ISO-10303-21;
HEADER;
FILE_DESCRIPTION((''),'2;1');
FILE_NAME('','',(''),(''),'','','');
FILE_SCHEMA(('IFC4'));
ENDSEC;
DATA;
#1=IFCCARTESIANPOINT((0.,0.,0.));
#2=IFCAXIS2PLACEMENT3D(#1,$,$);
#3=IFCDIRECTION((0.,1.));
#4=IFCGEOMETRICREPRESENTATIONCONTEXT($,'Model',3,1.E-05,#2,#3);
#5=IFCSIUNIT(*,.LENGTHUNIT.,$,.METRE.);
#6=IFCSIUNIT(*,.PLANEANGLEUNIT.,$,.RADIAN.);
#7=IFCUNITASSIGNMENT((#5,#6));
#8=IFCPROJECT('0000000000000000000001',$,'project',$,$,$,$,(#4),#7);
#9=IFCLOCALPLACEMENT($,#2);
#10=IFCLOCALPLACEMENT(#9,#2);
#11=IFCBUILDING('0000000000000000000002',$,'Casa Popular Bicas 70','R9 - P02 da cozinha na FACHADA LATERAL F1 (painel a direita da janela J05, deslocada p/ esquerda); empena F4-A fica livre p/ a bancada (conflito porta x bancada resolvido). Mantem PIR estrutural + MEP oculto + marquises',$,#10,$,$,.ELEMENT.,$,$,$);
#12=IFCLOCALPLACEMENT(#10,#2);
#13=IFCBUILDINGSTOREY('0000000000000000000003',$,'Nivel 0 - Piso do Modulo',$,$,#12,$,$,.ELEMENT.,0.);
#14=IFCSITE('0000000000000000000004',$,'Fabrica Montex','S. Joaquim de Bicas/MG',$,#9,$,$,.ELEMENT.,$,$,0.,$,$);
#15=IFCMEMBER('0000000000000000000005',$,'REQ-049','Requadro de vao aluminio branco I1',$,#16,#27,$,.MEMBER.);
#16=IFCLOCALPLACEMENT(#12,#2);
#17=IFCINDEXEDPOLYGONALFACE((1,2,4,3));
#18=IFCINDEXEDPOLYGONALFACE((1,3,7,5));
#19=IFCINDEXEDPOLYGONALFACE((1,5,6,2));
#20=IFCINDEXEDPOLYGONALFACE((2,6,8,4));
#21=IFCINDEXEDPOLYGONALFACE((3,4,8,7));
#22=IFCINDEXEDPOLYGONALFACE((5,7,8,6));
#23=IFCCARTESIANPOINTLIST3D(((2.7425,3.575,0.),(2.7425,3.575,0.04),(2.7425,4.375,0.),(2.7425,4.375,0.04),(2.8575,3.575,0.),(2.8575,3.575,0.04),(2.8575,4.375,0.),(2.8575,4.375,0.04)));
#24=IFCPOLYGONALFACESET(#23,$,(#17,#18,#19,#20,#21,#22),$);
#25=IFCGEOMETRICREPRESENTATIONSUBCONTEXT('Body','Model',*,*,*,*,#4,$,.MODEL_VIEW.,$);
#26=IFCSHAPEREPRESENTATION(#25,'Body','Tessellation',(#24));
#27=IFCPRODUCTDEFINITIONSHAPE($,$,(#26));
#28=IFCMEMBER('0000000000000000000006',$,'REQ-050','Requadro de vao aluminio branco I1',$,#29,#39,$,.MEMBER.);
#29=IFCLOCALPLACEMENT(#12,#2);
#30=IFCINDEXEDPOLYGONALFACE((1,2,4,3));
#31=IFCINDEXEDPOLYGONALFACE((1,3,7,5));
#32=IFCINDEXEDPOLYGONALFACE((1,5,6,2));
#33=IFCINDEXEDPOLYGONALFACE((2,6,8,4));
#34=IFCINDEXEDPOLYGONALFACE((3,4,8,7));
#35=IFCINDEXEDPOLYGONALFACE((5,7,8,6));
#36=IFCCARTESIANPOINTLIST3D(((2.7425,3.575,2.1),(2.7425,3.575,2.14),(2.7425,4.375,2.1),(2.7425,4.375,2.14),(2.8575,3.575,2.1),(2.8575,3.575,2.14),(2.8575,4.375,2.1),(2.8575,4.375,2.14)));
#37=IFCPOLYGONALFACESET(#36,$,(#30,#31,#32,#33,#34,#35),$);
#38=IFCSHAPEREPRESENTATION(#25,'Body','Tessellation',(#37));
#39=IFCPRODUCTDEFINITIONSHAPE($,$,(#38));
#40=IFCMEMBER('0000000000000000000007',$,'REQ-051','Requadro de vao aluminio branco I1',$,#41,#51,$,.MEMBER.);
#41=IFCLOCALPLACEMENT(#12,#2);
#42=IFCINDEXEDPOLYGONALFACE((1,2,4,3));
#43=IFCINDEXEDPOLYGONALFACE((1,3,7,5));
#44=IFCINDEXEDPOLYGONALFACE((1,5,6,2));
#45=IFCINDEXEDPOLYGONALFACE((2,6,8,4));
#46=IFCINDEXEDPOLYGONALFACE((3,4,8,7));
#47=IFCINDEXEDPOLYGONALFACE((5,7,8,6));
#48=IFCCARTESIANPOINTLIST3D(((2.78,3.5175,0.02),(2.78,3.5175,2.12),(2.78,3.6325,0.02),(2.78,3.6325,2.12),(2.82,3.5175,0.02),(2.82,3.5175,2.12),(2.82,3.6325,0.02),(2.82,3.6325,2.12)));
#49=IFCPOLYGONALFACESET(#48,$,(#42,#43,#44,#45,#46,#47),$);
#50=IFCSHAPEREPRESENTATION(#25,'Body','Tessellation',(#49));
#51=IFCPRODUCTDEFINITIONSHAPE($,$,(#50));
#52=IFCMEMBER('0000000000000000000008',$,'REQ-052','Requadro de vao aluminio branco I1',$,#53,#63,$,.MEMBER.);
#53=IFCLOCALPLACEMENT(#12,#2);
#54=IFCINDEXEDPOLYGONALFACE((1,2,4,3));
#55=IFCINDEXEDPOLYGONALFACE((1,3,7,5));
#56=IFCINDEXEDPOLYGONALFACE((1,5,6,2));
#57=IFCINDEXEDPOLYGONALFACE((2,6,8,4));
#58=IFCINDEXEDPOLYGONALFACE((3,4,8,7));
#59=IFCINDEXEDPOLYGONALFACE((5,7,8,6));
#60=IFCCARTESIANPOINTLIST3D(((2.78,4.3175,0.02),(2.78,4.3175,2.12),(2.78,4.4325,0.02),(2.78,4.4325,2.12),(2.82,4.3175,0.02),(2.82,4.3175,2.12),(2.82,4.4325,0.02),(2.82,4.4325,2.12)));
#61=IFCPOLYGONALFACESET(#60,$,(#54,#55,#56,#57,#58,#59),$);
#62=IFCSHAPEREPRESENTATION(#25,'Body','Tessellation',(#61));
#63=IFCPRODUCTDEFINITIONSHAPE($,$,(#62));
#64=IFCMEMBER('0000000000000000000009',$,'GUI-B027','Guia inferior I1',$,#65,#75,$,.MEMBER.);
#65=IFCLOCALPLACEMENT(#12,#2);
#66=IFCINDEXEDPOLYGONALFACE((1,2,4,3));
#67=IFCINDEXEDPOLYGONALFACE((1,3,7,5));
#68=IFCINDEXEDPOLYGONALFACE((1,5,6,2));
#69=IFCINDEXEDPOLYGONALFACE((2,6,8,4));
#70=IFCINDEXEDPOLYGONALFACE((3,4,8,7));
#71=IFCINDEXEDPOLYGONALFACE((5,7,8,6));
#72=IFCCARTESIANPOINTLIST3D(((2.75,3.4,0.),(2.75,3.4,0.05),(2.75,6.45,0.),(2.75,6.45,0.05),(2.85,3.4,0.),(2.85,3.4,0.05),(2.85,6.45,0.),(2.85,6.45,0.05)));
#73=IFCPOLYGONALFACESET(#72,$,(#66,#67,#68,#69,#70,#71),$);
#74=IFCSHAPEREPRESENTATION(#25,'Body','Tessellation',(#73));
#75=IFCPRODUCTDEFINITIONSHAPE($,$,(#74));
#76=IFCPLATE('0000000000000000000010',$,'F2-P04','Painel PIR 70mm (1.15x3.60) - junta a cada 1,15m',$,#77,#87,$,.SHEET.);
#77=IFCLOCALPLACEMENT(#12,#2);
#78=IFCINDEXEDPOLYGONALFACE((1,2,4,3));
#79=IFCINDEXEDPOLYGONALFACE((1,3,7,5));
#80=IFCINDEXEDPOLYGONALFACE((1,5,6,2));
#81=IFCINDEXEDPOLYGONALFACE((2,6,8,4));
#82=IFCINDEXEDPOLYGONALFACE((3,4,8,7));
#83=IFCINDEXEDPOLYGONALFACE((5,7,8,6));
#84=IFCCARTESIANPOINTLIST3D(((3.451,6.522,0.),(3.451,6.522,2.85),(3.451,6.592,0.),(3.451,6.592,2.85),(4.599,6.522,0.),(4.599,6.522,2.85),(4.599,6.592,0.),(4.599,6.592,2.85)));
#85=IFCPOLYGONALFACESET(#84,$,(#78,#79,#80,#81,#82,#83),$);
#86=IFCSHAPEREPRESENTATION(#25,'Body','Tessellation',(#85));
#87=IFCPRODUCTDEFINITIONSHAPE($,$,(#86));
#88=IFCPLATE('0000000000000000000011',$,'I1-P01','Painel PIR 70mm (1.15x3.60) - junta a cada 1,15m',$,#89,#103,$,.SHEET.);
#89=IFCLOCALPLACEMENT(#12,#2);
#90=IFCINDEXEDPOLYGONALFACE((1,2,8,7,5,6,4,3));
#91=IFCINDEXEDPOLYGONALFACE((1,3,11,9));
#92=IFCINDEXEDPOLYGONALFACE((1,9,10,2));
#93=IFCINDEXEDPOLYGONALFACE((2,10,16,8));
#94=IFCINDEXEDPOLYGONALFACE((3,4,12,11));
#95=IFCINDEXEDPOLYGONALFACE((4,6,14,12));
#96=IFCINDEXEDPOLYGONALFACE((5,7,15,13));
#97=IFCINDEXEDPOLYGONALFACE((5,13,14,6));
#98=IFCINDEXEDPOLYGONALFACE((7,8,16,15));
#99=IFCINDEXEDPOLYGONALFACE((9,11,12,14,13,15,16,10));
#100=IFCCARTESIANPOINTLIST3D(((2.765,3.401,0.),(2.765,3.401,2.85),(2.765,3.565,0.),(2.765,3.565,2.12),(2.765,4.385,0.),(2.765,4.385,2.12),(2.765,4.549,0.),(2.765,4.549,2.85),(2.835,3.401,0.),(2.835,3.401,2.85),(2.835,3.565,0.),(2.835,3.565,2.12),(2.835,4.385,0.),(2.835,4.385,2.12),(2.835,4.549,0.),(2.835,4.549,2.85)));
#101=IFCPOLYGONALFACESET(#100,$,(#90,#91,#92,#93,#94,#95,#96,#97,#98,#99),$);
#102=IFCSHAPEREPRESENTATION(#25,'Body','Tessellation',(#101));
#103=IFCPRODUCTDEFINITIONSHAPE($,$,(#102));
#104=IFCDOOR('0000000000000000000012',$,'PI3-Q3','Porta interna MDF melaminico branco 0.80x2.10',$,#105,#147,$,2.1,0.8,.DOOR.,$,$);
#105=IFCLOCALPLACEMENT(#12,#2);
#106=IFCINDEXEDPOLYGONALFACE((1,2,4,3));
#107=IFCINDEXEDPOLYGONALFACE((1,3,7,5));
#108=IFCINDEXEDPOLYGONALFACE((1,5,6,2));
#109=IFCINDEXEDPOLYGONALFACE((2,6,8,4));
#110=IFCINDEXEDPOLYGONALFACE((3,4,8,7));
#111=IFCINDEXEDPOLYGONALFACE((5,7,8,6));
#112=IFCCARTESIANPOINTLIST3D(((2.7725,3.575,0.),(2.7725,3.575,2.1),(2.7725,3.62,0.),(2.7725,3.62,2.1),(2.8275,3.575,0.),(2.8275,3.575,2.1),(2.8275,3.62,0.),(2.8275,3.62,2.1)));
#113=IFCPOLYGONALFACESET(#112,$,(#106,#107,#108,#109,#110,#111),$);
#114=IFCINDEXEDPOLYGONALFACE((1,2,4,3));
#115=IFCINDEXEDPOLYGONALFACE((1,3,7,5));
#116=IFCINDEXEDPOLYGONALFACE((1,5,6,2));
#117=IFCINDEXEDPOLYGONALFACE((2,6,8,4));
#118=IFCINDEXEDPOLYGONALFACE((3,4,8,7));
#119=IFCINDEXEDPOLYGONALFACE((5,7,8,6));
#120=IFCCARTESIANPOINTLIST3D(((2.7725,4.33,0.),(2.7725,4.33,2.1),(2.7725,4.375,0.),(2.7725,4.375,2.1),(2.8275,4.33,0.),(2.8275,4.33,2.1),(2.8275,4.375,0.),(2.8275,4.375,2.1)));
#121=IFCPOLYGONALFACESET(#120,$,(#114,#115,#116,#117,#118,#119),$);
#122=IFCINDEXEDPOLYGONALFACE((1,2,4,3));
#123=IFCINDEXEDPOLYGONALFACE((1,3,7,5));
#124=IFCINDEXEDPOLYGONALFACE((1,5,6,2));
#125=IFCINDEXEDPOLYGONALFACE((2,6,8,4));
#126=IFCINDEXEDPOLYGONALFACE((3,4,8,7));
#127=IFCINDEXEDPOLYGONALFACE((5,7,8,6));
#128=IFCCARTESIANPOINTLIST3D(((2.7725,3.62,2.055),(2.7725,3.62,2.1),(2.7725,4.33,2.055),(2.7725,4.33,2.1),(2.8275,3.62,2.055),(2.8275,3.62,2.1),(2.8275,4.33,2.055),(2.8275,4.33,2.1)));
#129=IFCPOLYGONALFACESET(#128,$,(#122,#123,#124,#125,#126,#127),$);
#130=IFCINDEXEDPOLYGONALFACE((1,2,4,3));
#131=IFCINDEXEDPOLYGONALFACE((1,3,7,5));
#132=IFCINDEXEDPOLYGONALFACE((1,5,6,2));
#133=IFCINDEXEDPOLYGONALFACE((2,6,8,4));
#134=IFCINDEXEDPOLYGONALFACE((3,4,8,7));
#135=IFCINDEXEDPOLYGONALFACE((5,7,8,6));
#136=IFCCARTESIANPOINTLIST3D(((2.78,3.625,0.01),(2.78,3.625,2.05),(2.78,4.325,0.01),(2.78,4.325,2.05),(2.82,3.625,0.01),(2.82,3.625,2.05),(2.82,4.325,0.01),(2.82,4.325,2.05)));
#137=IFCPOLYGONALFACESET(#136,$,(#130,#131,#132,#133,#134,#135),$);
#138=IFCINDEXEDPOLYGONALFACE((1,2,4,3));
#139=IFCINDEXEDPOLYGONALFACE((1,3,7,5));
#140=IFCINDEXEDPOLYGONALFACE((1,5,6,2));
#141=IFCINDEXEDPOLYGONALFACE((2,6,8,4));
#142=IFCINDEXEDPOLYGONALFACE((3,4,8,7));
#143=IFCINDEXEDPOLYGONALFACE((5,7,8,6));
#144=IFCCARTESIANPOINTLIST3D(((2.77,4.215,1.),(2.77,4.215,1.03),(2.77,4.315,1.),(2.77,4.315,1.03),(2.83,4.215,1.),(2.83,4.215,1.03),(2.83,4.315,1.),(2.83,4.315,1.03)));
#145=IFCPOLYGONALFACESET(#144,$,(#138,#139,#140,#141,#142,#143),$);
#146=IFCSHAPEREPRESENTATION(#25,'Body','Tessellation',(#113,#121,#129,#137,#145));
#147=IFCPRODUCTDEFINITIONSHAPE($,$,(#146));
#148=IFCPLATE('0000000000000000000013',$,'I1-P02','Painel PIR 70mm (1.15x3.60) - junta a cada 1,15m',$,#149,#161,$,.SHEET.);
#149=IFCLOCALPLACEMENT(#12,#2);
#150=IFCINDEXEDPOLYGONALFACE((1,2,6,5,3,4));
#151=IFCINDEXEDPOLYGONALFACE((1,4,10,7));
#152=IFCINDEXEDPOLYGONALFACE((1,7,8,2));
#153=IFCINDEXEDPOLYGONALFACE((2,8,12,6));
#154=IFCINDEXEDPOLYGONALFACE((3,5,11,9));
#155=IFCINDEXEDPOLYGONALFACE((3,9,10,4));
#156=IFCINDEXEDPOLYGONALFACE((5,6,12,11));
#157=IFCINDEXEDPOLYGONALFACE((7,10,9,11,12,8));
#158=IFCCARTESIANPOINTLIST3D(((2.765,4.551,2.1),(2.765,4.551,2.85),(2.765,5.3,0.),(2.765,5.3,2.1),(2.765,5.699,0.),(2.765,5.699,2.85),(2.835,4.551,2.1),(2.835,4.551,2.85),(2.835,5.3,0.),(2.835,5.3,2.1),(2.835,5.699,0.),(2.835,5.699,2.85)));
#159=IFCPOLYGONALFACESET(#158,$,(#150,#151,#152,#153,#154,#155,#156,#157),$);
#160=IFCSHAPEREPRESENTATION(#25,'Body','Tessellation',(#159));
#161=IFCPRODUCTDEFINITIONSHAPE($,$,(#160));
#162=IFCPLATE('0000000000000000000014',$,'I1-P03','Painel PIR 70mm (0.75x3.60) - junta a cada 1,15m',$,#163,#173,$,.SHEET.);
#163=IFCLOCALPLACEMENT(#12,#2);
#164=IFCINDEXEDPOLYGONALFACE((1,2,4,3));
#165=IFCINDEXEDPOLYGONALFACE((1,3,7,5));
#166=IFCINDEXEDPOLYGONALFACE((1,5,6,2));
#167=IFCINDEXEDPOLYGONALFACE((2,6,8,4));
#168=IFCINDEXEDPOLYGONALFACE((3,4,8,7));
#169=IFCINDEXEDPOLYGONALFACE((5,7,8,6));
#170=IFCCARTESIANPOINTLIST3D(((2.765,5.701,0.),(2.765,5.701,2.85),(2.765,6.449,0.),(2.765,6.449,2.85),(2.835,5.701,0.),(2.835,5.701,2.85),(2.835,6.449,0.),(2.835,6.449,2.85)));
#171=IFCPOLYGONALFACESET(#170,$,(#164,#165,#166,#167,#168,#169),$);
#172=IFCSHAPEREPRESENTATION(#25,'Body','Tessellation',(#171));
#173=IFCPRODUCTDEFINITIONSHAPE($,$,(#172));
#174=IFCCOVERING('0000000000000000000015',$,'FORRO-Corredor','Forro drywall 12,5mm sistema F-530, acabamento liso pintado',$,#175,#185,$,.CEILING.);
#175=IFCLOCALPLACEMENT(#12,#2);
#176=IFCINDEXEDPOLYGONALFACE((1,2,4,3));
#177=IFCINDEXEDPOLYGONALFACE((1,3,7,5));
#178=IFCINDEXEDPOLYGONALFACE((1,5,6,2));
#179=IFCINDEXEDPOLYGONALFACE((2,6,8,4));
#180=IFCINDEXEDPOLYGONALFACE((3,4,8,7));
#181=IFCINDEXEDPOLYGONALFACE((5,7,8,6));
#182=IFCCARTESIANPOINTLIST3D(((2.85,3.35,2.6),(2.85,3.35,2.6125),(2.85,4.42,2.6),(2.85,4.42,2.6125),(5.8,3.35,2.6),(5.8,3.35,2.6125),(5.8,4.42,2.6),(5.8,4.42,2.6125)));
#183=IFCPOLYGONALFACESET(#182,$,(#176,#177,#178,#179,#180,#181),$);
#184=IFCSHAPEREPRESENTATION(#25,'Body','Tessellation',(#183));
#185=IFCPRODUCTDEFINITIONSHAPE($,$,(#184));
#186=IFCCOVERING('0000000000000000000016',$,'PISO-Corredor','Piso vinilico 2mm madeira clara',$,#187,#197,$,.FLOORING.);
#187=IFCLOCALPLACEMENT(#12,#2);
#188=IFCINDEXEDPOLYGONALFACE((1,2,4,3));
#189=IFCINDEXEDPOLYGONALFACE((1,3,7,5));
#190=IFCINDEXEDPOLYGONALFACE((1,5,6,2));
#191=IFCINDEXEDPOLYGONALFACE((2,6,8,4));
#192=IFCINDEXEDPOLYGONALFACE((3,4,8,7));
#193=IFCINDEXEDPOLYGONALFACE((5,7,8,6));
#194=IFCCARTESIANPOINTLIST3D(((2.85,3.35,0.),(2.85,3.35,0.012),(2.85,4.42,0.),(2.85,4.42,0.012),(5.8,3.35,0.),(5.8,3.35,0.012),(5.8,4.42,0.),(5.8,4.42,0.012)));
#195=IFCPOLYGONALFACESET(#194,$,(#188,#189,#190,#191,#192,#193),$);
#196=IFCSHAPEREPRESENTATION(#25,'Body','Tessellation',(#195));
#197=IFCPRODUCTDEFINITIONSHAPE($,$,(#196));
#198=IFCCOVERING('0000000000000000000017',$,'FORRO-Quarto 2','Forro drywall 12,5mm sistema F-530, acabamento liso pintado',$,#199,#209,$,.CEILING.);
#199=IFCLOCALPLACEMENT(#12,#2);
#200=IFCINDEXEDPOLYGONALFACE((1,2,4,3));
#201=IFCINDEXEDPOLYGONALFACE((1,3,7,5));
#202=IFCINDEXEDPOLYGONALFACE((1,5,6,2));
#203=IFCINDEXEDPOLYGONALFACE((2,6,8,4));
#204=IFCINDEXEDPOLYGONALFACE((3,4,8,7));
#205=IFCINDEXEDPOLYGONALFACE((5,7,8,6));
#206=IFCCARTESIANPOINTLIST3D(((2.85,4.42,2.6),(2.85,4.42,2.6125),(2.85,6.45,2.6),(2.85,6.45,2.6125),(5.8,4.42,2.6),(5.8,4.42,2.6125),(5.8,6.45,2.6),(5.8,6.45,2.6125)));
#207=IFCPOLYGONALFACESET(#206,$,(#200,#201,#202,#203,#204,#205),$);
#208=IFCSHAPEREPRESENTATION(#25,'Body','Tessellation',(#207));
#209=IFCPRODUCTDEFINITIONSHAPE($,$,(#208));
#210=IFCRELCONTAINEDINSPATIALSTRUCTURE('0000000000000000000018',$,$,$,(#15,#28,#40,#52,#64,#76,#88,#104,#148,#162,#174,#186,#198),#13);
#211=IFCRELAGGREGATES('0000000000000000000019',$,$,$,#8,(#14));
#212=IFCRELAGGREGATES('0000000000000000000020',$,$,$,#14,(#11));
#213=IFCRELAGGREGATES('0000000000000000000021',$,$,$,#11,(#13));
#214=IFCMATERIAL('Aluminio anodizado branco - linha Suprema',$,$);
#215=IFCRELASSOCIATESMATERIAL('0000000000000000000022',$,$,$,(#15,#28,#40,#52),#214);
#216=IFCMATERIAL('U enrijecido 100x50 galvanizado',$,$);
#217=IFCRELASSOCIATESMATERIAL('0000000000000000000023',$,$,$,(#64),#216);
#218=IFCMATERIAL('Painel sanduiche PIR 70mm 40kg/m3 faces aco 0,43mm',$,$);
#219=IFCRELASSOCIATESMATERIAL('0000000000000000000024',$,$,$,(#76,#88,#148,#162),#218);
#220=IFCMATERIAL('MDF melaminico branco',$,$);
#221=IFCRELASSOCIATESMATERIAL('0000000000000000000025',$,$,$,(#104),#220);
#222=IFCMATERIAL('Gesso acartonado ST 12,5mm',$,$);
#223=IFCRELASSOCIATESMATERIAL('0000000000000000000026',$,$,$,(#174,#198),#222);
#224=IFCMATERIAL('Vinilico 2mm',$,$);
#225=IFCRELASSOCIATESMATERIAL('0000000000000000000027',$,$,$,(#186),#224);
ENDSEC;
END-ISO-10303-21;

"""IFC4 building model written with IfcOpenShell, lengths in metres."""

from ifc_helpers import new_model, si_unit, direction, frame, frame_2d, origin, origin_2d, place, context, subcontext, project, spatial, rectangle, extrude, material, element, fill, save


model = new_model("IFC4")

# Units and contexts
model_context = context("Model", 3, precision=1e-05, world=origin(), true_north=direction((0.0, 1.0)))
body_context = subcontext(model_context, "Body", "Model", "MODEL_VIEW")
ifc_project = project(units=[si_unit("LENGTHUNIT", "METRE"), si_unit("PLANEANGLEUNIT", "RADIAN")], contexts=[model_context])

# Site, building, storey
site_placement = place(None, origin())
site = spatial("IfcSite", under=ifc_project, at=site_placement, Name="Fabrica Montex", Description="S. Joaquim de Bicas/MG", CompositionType="ELEMENT", RefElevation=0.0)
building_placement = place(site_placement, origin())
building = spatial("IfcBuilding", under=site, at=building_placement, Name="Casa Popular Bicas 70", Description="R9 - P02 da cozinha na FACHADA LATERAL F1 (painel a direita da janela J05, deslocada p/ esquerda); empena F4-A fica livre p/ a bancada (conflito porta x bancada resolvido). Mantem PIR estrutural + MEP oculto + marquises", CompositionType="ELEMENT")
storey_placement = place(building_placement, origin())
storey = spatial("IfcBuildingStorey", under=building, at=storey_placement, Name="Nivel 0 - Piso do Modulo", CompositionType="ELEMENT", Elevation=0.0)

# Members
ifc_material_1 = material(Name="Aluminio anodizado branco - linha Suprema")
for number, where, z_axis, x_axis, name in (
    (1, (2.8, 3.575, 0.02), (0.0, 1.0, 0.0), (0.0, 0.0, 1.0), "REQ-049"),
    (2, (2.8, 3.575, 2.12), (0.0, 1.0, 0.0), (0.0, 0.0, 1.0), "REQ-050"),
):
    element("IfcMember", number, at=place(storey_placement, frame(where, z_axis=z_axis, x_axis=x_axis)), inside=storey, material=ifc_material_1, Name=name, Description="Requadro de vao aluminio branco I1", PredefinedType="MEMBER", context=body_context, shape_type="SweptSolid", body=[
        extrude(rectangle(XDim=0.04, YDim=0.115, at=origin_2d()), origin(), (0.0, 0.0, 1.0), 0.8),
    ])
for number, where, z_axis, x_axis, name in (
    (3, (2.8, 3.575, 0.02), (0.0, 0.0, 1.0), (1.0, 0.0, 0.0), "REQ-051"),
    (4, (2.8, 4.375, 0.02), (0.0, 0.0, 1.0), (1.0, 0.0, 0.0), "REQ-052"),
):
    element("IfcMember", number, at=place(storey_placement, frame(where, z_axis=z_axis, x_axis=x_axis)), inside=storey, material=ifc_material_1, Name=name, Description="Requadro de vao aluminio branco I1", PredefinedType="MEMBER", context=body_context, shape_type="SweptSolid", body=[
        extrude(rectangle(XDim=0.04, YDim=0.115, at=origin_2d()), origin(), (0.0, 0.0, 1.0), 2.1),
    ])
ifc_material_2 = material(Name="U enrijecido 100x50 galvanizado")
member_placement = place(storey_placement, frame((2.8, 3.4, 0.025), z_axis=(0.0, 1.0, 0.0), x_axis=(0.0, 0.0, 1.0)))
element("IfcMember", 5, at=member_placement, inside=storey, material=ifc_material_2, Name="GUI-B027", Description="Guia inferior I1", PredefinedType="MEMBER", context=body_context, shape_type="SweptSolid", body=[
    extrude(rectangle(XDim=0.05, YDim=0.1, at=origin_2d()), origin(), (0.0, 0.0, 1.0), 3.05),
])

# Plate
ifc_material_3 = material(Name="Painel sanduiche PIR 70mm 40kg/m3 faces aco 0,43mm")
plate_1_placement = place(storey_placement, frame((3.451, 6.557, 0.0), x_axis=(1.0, 0.0, 0.0)))
element("IfcPlate", 6, at=plate_1_placement, inside=storey, material=ifc_material_3, Name="F2-P04", Description="Painel PIR 70mm (1.15x3.60) - junta a cada 1,15m", PredefinedType="SHEET", context=body_context, shape_type="SweptSolid", body=[
    extrude(rectangle(XDim=1.148, YDim=0.07, at=frame_2d((0.574, 0.0))), origin(), (0.0, 0.0, 1.0), 2.85),
])

# Plate, opening, door
plate_2_placement = place(storey_placement, frame((2.8, 3.401, 0.0), x_axis=(0.0, 1.0, 0.0)))
plate_2 = element("IfcPlate", 7, at=plate_2_placement, inside=storey, material=ifc_material_3, Name="I1-P01", Description="Painel PIR 70mm (1.15x3.60) - junta a cada 1,15m", PredefinedType="SHEET", context=body_context, shape_type="SweptSolid", body=[
    extrude(rectangle(XDim=1.148, YDim=0.07, at=frame_2d((0.574, 0.0))), origin(), (0.0, 0.0, 1.0), 2.85),
])
opening_1_placement = place(storey_placement, frame((2.8, 3.575, 0.0), x_axis=(0.0, 1.0, 0.0)))
opening_1 = element("IfcOpeningElement", 8, at=opening_1_placement, cuts=plate_2, PredefinedType="OPENING", context=body_context, shape_type="SweptSolid", body=[
    extrude(rectangle(XDim=0.82, YDim=0.3, at=frame_2d((0.4, 0.0))), origin(), (0.0, 0.0, 1.0), 2.12),
])
ifc_material_4 = material(Name="MDF melaminico branco")
door_placement = place(storey_placement, frame((2.8, 3.575, 0.0), x_axis=(0.0, 1.0, 0.0)))
door = element("IfcDoor", 9, at=door_placement, inside=storey, material=ifc_material_4, Name="PI3-Q3", Description="Porta interna MDF melaminico branco 0.80x2.10", OverallHeight=2.1, OverallWidth=0.8, PredefinedType="DOOR", context=body_context, shape_type="SweptSolid", body=[
    extrude(rectangle(XDim=0.045, YDim=0.055, at=frame_2d((0.0225, 0.0))), origin(), (0.0, 0.0, 1.0), 2.1),
    extrude(rectangle(XDim=0.045, YDim=0.055, at=frame_2d((0.7775, 0.0))), origin(), (0.0, 0.0, 1.0), 2.1),
    extrude(rectangle(XDim=0.71, YDim=0.055, at=frame_2d((0.4, 0.0))), frame((0.0, 0.0, 2.055)), (0.0, 0.0, 1.0), 0.045),
    extrude(rectangle(XDim=0.7, YDim=0.04, at=frame_2d((0.4, 0.0))), frame((0.0, 0.0, 0.01)), (0.0, 0.0, 1.0), 2.04),
    extrude(rectangle(XDim=0.1, YDim=0.06, at=frame_2d((0.69, 0.0))), frame((0.0, 0.0, 1.0)), (0.0, 0.0, 1.0), 0.03),
])
fill(opening_1, door)

# Plate, opening
plate_3_placement = place(storey_placement, frame((2.8, 4.551, 0.0), x_axis=(0.0, 1.0, 0.0)))
plate_3 = element("IfcPlate", 10, at=plate_3_placement, inside=storey, material=ifc_material_3, Name="I1-P02", Description="Painel PIR 70mm (1.15x3.60) - junta a cada 1,15m", PredefinedType="SHEET", context=body_context, shape_type="SweptSolid", body=[
    extrude(rectangle(XDim=1.148, YDim=0.07, at=frame_2d((0.574, 0.0))), origin(), (0.0, 0.0, 1.0), 2.85),
])
opening_2_placement = place(storey_placement, frame((2.8, 4.925, 0.0)))
element("IfcOpeningElement", 11, at=opening_2_placement, cuts=plate_3, PredefinedType="OPENING", context=body_context, shape_type="SweptSolid", body=[
    extrude(rectangle(XDim=0.1, YDim=0.75, at=origin_2d()), origin(), (0.0, 0.0, 1.0), 2.1),
])

# Plate
plate_4_placement = place(storey_placement, frame((2.8, 5.701, 0.0), x_axis=(0.0, 1.0, 0.0)))
element("IfcPlate", 12, at=plate_4_placement, inside=storey, material=ifc_material_3, Name="I1-P03", Description="Painel PIR 70mm (0.75x3.60) - junta a cada 1,15m", PredefinedType="SHEET", context=body_context, shape_type="SweptSolid", body=[
    extrude(rectangle(XDim=0.748, YDim=0.07, at=frame_2d((0.374, 0.0))), origin(), (0.0, 0.0, 1.0), 2.85),
])

# Coverings
ifc_material_5 = material(Name="Gesso acartonado ST 12,5mm")
covering_1_placement = place(storey_placement, frame((2.85, 3.35, 2.6)))
element("IfcCovering", 13, at=covering_1_placement, inside=storey, material=ifc_material_5, Name="FORRO-Corredor", Description="Forro drywall 12,5mm sistema F-530, acabamento liso pintado", PredefinedType="CEILING", context=body_context, shape_type="SweptSolid", body=[
    extrude(rectangle(XDim=2.95, YDim=1.07, at=frame_2d((1.475, 0.535))), origin(), (0.0, 0.0, 1.0), 0.0125),
])
ifc_material_6 = material(Name="Vinilico 2mm")
covering_2_placement = place(storey_placement, frame((2.85, 3.35, 0.0)))
element("IfcCovering", 14, at=covering_2_placement, inside=storey, material=ifc_material_6, Name="PISO-Corredor", Description="Piso vinilico 2mm madeira clara", PredefinedType="FLOORING", context=body_context, shape_type="SweptSolid", body=[
    extrude(rectangle(XDim=2.95, YDim=1.07, at=frame_2d((1.475, 0.535))), origin(), (0.0, 0.0, 1.0), 0.012),
])
covering_3_placement = place(storey_placement, frame((2.85, 4.42, 2.6)))
element("IfcCovering", 15, at=covering_3_placement, inside=storey, material=ifc_material_5, Name="FORRO-Quarto 2", Description="Forro drywall 12,5mm sistema F-530, acabamento liso pintado", PredefinedType="CEILING", context=body_context, shape_type="SweptSolid", body=[
    extrude(rectangle(XDim=2.95, YDim=2.03, at=frame_2d((1.475, 1.015))), origin(), (0.0, 0.0, 1.0), 0.0125),
])

save(model, "model.ifc")
